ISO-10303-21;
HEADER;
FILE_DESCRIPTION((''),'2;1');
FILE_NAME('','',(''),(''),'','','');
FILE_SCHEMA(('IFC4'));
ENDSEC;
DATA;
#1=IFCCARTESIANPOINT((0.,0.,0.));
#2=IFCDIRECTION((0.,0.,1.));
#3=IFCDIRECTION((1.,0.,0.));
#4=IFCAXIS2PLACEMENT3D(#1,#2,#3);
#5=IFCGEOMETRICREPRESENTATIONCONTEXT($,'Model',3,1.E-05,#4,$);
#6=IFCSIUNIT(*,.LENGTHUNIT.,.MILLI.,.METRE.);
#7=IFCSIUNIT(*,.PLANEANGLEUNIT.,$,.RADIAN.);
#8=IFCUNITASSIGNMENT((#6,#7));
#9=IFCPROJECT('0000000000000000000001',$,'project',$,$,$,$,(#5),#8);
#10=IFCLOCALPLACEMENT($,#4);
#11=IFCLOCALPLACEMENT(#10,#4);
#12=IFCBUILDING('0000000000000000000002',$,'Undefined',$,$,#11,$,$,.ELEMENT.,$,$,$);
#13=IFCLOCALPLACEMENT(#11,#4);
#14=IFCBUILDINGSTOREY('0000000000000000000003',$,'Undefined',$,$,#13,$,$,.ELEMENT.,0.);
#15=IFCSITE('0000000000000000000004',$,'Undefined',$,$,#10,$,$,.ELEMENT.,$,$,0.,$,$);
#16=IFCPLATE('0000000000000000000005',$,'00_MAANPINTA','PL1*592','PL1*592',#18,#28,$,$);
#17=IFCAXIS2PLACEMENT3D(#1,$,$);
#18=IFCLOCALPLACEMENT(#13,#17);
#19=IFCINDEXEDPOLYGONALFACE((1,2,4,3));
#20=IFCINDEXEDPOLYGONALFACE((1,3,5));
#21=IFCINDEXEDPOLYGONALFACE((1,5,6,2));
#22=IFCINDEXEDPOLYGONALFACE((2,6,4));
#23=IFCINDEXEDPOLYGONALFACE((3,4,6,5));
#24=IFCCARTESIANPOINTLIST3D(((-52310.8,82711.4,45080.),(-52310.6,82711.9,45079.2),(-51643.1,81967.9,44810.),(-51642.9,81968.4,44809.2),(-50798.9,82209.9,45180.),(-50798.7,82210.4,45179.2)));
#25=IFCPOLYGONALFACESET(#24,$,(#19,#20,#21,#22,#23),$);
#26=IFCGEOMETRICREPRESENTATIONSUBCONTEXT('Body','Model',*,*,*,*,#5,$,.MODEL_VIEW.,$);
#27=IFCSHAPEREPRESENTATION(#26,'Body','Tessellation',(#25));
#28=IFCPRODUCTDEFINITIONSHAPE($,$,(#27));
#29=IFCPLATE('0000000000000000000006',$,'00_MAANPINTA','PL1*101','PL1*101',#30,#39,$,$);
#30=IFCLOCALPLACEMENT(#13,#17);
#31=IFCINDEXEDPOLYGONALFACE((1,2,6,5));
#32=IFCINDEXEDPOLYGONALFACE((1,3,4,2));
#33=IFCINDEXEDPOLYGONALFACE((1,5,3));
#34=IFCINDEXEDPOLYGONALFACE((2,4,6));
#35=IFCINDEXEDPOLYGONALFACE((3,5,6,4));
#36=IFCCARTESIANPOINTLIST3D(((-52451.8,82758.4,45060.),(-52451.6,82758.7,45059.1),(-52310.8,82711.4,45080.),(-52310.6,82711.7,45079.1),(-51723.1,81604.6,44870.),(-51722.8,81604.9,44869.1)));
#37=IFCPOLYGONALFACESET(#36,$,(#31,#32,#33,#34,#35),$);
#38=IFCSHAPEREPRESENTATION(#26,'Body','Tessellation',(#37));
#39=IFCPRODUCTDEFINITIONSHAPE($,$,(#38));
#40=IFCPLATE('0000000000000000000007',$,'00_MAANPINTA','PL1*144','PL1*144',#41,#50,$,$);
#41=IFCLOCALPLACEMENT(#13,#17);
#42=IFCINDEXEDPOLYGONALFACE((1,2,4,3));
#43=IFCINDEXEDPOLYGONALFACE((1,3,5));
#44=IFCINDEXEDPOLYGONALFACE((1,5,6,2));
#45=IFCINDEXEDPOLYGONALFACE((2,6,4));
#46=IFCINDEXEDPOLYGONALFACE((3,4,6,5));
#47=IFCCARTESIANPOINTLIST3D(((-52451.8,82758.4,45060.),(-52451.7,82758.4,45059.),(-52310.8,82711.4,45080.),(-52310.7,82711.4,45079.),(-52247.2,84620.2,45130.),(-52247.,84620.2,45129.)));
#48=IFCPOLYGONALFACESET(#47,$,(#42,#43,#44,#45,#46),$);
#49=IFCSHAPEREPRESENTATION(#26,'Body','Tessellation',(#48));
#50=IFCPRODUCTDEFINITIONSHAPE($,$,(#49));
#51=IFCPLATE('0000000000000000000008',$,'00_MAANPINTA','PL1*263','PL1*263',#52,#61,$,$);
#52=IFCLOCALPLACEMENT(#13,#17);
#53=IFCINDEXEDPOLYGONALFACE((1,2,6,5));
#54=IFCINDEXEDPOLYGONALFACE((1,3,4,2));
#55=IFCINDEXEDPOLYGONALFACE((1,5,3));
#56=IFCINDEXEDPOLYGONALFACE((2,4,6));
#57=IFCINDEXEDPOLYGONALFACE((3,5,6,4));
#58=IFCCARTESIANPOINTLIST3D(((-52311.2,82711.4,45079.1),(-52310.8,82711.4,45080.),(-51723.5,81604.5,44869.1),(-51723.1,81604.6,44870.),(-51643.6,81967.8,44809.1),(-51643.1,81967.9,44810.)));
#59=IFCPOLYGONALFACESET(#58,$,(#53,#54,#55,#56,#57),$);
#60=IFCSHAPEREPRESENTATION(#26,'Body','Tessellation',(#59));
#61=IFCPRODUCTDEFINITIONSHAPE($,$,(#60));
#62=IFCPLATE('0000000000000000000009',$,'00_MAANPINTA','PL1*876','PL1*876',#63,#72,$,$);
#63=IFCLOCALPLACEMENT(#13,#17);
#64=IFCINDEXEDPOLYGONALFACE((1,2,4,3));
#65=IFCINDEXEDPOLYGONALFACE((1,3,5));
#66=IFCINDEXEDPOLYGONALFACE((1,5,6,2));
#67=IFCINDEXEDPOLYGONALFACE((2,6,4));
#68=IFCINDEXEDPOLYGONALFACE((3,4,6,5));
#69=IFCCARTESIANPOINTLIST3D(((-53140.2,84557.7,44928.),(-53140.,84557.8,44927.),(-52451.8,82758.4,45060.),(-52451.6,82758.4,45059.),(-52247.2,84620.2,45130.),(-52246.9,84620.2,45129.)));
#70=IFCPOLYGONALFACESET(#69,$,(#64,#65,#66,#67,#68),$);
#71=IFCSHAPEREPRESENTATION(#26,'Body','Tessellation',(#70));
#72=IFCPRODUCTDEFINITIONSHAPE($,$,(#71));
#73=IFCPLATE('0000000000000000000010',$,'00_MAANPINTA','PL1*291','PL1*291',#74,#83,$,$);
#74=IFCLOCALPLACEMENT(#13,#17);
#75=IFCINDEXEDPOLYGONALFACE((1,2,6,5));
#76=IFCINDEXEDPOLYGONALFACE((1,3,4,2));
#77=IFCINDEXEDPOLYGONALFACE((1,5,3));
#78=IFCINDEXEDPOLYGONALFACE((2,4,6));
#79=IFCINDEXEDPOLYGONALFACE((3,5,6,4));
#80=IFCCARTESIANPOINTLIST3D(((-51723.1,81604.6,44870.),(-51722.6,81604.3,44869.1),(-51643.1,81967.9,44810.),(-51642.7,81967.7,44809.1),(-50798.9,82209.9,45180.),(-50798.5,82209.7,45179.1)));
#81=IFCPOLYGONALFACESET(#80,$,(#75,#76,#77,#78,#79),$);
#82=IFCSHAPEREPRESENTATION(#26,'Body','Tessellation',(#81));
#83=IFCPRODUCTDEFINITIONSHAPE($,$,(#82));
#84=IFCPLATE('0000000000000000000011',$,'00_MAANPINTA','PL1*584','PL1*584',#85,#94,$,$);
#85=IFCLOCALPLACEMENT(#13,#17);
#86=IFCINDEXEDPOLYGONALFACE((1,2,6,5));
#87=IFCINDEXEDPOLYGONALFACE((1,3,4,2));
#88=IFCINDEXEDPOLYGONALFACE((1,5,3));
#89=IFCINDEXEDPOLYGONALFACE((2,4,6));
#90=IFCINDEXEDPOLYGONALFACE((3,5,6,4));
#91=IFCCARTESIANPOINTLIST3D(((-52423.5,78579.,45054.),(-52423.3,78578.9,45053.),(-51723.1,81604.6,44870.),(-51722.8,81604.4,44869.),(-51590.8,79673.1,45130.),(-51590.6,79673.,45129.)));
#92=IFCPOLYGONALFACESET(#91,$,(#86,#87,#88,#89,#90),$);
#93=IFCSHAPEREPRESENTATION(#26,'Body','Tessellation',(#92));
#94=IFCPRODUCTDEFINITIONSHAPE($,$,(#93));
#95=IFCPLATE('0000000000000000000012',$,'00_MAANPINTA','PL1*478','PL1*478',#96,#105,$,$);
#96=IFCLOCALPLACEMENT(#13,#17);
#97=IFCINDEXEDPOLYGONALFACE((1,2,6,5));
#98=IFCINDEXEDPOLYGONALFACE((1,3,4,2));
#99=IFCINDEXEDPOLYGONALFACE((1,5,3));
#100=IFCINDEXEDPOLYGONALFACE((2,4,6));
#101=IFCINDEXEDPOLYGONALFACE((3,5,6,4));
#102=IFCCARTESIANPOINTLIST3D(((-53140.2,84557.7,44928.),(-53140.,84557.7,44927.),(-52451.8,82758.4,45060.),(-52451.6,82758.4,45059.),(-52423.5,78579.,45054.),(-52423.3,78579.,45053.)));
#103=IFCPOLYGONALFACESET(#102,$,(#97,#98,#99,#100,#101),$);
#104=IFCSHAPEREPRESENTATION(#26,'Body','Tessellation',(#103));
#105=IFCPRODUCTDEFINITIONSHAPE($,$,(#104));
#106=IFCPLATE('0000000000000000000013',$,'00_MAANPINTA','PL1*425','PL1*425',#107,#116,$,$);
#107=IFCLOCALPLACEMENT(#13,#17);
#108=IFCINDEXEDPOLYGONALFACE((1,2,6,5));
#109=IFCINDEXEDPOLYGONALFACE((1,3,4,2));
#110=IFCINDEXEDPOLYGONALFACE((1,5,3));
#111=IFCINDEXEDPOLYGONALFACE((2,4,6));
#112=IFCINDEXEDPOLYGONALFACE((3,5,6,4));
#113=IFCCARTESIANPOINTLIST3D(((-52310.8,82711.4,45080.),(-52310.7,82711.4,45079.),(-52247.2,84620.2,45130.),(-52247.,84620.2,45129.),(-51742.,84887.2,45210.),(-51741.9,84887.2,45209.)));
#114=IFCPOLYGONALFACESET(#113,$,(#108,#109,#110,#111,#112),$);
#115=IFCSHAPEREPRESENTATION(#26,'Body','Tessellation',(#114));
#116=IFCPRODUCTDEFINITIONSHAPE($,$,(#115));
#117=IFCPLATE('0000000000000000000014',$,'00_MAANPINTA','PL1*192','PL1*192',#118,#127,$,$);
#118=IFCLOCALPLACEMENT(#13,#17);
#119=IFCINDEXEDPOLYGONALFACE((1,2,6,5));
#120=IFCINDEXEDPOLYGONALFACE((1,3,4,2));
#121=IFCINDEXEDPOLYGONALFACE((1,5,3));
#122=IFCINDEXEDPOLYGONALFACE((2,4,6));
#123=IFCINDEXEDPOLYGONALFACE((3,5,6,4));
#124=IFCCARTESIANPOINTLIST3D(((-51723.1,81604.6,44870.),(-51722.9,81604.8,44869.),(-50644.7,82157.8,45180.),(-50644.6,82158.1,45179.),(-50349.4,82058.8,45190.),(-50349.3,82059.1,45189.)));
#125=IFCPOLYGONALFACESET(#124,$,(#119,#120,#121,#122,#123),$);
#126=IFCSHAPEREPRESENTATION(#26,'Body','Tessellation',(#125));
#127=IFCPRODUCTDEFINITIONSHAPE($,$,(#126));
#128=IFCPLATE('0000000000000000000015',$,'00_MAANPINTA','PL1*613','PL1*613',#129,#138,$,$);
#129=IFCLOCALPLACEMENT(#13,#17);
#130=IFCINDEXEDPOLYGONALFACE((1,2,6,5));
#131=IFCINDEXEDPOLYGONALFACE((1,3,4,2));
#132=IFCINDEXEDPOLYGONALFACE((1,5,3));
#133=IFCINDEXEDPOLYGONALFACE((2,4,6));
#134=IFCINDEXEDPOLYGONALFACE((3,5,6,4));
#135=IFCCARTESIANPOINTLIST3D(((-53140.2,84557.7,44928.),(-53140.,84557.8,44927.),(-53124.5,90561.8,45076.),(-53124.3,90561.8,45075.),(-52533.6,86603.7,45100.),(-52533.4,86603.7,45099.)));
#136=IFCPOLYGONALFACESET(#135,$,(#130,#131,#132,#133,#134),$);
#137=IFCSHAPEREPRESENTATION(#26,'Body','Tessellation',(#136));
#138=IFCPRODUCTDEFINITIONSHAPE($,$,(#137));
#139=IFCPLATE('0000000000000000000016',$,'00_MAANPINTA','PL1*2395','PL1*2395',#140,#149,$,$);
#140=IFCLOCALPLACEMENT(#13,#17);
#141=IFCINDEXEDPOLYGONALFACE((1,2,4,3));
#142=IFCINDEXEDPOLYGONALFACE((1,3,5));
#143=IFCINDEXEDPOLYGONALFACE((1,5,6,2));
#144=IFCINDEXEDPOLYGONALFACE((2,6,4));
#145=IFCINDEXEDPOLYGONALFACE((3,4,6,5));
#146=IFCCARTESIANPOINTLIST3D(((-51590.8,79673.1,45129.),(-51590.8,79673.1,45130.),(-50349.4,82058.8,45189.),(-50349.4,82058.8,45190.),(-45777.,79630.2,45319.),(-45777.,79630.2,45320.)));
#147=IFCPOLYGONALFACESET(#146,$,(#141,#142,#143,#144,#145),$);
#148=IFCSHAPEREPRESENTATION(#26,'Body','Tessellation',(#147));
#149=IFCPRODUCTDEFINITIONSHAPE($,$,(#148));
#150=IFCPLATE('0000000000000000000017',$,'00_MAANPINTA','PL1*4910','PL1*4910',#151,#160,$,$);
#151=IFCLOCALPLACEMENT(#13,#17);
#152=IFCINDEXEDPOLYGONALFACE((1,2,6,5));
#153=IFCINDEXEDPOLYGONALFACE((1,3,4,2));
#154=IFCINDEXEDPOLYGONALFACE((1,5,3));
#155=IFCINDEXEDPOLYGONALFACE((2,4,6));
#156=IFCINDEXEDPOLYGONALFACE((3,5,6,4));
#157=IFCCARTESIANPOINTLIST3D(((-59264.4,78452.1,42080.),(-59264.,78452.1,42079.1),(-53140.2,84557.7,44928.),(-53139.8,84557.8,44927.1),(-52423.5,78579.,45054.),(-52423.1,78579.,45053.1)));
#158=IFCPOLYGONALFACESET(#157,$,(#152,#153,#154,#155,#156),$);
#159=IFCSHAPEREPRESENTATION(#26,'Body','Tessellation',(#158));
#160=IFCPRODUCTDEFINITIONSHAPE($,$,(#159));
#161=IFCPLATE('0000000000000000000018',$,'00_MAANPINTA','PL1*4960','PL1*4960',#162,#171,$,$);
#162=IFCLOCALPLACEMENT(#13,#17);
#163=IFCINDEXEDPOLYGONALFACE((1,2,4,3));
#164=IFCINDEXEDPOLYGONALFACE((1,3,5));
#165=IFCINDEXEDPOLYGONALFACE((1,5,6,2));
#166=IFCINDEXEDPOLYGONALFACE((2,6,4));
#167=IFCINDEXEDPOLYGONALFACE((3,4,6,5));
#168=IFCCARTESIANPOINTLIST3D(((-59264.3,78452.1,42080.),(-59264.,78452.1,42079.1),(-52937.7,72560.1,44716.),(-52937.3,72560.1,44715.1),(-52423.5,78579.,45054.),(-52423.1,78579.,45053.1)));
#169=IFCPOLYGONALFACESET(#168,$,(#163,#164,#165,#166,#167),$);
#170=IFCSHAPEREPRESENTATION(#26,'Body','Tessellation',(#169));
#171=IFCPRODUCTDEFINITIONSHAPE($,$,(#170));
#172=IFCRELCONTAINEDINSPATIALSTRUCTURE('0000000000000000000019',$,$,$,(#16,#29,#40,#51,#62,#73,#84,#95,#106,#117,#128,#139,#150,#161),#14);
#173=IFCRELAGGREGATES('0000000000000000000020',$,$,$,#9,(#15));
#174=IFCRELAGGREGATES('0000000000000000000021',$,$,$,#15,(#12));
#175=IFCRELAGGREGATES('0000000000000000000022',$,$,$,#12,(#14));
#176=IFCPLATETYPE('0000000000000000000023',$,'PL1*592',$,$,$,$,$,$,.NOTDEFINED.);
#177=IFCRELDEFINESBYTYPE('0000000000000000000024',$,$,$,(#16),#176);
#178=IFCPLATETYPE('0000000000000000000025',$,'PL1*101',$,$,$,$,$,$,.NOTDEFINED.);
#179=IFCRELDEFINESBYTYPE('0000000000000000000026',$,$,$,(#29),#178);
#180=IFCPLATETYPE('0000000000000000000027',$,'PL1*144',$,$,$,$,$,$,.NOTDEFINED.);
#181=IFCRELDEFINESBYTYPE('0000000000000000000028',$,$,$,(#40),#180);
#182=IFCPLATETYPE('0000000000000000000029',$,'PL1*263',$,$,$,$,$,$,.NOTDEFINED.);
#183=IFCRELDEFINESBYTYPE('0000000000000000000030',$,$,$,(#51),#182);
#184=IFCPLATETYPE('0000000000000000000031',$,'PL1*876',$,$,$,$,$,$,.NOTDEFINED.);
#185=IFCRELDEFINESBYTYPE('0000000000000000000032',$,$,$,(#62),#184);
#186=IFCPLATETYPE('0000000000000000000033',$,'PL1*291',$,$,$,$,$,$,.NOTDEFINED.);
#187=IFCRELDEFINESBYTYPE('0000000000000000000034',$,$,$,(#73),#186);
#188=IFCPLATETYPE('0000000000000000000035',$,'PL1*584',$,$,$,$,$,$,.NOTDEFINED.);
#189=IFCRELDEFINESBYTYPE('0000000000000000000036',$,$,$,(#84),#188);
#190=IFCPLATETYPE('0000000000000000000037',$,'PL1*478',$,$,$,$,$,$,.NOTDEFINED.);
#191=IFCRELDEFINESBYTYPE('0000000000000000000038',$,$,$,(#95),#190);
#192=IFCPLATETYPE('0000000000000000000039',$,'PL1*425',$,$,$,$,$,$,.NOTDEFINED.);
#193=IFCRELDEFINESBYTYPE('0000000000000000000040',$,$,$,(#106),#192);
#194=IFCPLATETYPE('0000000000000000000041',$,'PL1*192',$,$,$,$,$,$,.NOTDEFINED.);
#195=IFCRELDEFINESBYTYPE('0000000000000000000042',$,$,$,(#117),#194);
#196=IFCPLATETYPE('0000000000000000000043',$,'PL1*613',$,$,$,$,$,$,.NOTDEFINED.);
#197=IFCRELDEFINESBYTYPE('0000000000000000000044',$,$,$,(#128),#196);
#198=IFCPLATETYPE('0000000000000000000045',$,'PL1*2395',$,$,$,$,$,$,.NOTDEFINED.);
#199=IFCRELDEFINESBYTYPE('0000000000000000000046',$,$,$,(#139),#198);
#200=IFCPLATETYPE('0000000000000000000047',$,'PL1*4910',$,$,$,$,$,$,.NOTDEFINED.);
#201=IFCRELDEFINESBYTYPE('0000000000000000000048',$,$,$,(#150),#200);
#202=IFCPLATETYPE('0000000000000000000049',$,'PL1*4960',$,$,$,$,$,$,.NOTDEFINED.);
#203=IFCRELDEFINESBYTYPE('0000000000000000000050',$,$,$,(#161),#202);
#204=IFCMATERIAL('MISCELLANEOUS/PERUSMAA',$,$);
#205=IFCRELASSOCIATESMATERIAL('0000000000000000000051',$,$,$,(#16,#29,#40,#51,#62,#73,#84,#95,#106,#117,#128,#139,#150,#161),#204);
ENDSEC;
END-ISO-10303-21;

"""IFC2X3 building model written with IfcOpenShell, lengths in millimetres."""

from ifc_helpers import new_model, si_unit, frame, origin_with_axes, place, context, subcontext, project, spatial, polyline, outline, extrude, material, type_object, element, save


model = new_model("IFC2X3")

# Units and contexts
model_context = context("Model", 3, precision=1e-05, world=origin_with_axes())
body_context = subcontext(model_context, "Body", "Model", "MODEL_VIEW")
ifc_project = project(units=[si_unit("LENGTHUNIT", "METRE", prefix="MILLI"), si_unit("PLANEANGLEUNIT", "RADIAN")], contexts=[model_context])

# Site, building, storey
site_placement = place(None, origin_with_axes())
site = spatial("IfcSite", under=ifc_project, at=site_placement, Name="Undefined", CompositionType="ELEMENT", RefElevation=0.0)
building_placement = place(site_placement, origin_with_axes())
building = spatial("IfcBuilding", under=site, at=building_placement, Name="Undefined", CompositionType="ELEMENT")
storey_placement = place(building_placement, origin_with_axes())
storey = spatial("IfcBuildingStorey", under=building, at=storey_placement, Name="Undefined", CompositionType="ELEMENT", Elevation=0.0)

# Plates
ifc_material = material(Name="MISCELLANEOUS/PERUSMAA")
plate_type_1 = type_object("IfcPlateType", Name="PL1*592", PredefinedType="NOTDEFINED")
plate_1_placement = place(storey_placement, frame((-50798.8, 82210.2, 45179.6), z_axis=(0.222021, 0.50274, -0.83544), x_axis=(-0.88587, -0.253964, -0.38825)))
element("IfcPlate", 1, at=plate_1_placement, inside=storey, type_object=plate_type_1, material=ifc_material, Name="00_MAANPINTA", Description="PL1*592", ObjectType="PL1*592", context=body_context, shape_type="SweptSolid", body=[
    extrude(outline(polyline([(0.0, 0.0), (953.0, 0.0), (1250.8, 991.4), (0.0, 0.0)])), frame((0.0, 0.0, -0.5), z_axis=(0.0, 0.0, 1.0), x_axis=(1.0, 0.0, 0.0)), (0.0, 0.0, 1.0), 1.0),
])
plate_type_2 = type_object("IfcPlateType", Name="PL1*101", PredefinedType="NOTDEFINED")
plate_2_placement = place(storey_placement, frame((-51722.9, 81604.7, 44869.5), z_axis=(0.230678, 0.298213, -0.926206), x_axis=(-0.528911, 0.8374, 0.137891)))
element("IfcPlate", 2, at=plate_2_placement, inside=storey, type_object=plate_type_2, material=ifc_material, Name="00_MAANPINTA", Description="PL1*101", ObjectType="PL1*101", context=body_context, shape_type="SweptSolid", body=[
    extrude(outline(polyline([(0.0, 0.0), (1377.9, 0.0), (1266.7, 100.7), (0.0, 0.0)])), frame((0.0, 0.0, -0.5), z_axis=(0.0, 0.0, 1.0), x_axis=(1.0, 0.0, 0.0)), (0.0, 0.0, 1.0), 1.0),
])
plate_type_3 = type_object("IfcPlateType", Name="PL1*144", PredefinedType="NOTDEFINED")
plate_3_placement = place(storey_placement, frame((-52247.1, 84620.2, 45129.5), z_axis=(0.14722, 0.020995, -0.988881), x_axis=(-0.033318, -0.999102, -0.026172)))
element("IfcPlate", 3, at=plate_3_placement, inside=storey, type_object=plate_type_3, material=ifc_material, Name="00_MAANPINTA", Description="PL1*144", ObjectType="PL1*144", context=body_context, shape_type="SweptSolid", body=[
    extrude(outline(polyline([(0.0, 0.0), (1910.4, 0.0), (1868.7, 144.1), (0.0, 0.0)])), frame((0.0, 0.0, -0.5), z_axis=(0.0, 0.0, 1.0), x_axis=(1.0, 0.0, 0.0)), (0.0, 0.0, 1.0), 1.0),
])
plate_type_4 = type_object("IfcPlateType", Name="PL1*263", PredefinedType="NOTDEFINED")
plate_4_placement = place(storey_placement, frame((-52311.0, 82711.4, 45079.5), z_axis=(-0.426603, -0.055251, -0.90275), x_axis=(0.644994, -0.718295, -0.260836)))
element("IfcPlate", 4, at=plate_4_placement, inside=storey, type_object=plate_type_4, material=ifc_material, Name="00_MAANPINTA", Description="PL1*263", ObjectType="PL1*263", context=body_context, shape_type="SweptSolid", body=[
    extrude(outline(polyline([(0.0, 0.0), (1035.1, 0.0), (1228.9, 323.2), (0.0, 0.0)])), frame((0.0, 0.0, -0.5), z_axis=(0.0, 0.0, 1.0), x_axis=(1.0, 0.0, 0.0)), (0.0, 0.0, 1.0), 1.0),
])
plate_type_5 = type_object("IfcPlateType", Name="PL1*876", PredefinedType="NOTDEFINED")
plate_5_placement = place(storey_placement, frame((-52451.7, 82758.4, 45059.5), z_axis=(0.219776, 0.012513, -0.97547), x_axis=(-0.356459, 0.931807, -0.068358)))
element("IfcPlate", 5, at=plate_5_placement, inside=storey, type_object=plate_type_5, material=ifc_material, Name="00_MAANPINTA", Description="PL1*876", ObjectType="PL1*876", context=body_context, shape_type="SweptSolid", body=[
    extrude(outline(polyline([(0.0, 0.0), (1931.0, 0.0), (1657.0, 875.9), (0.0, 0.0)])), frame((0.0, 0.0, -0.5), z_axis=(0.0, 0.0, 1.0), x_axis=(1.0, 0.0, 0.0)), (0.0, 0.0, 1.0), 1.0),
])
plate_type_6 = type_object("IfcPlateType", Name="PL1*291", PredefinedType="NOTDEFINED")
plate_6_placement = place(storey_placement, frame((-51722.8, 81604.4, 44869.6), z_axis=(0.446646, -0.240542, -0.861769), x_axis=(0.21206, 0.964198, -0.159223)))
element("IfcPlate", 6, at=plate_6_placement, inside=storey, type_object=plate_type_6, material=ifc_material, Name="00_MAANPINTA", Description="PL1*291", ObjectType="PL1*291", context=body_context, shape_type="SweptSolid", body=[
    extrude(outline(polyline([(0.0, 0.0), (376.8, 0.0), (730.3, 885.0), (0.0, 0.0)])), frame((0.0, 0.0, -0.5), z_axis=(0.0, 0.0, 1.0), x_axis=(1.0, 0.0, 0.0)), (0.0, 0.0, 1.0), 1.0),
])
plate_type_7 = type_object("IfcPlateType", Name="PL1*584", PredefinedType="NOTDEFINED")
plate_7_placement = place(storey_placement, frame((-51722.9, 81604.5, 44869.5), z_axis=(0.23734, -0.113617, -0.96476), x_axis=(0.067711, -0.988786, 0.133104)))
element("IfcPlate", 7, at=plate_7_placement, inside=storey, type_object=plate_type_7, material=ifc_material, Name="00_MAANPINTA", Description="PL1*584", ObjectType="PL1*584", context=body_context, shape_type="SweptSolid", body=[
    extrude(outline(polyline([(0.0, 0.0), (1953.4, 0.0), (2968.7, 930.2), (0.0, 0.0)])), frame((0.0, 0.0, -0.5), z_axis=(0.0, 0.0, 1.0), x_axis=(1.0, 0.0, 0.0)), (0.0, 0.0, 1.0), 1.0),
])
plate_type_8 = type_object("IfcPlateType", Name="PL1*478", PredefinedType="NOTDEFINED")
plate_8_placement = place(storey_placement, frame((-52423.4, 78579.0, 45053.5), z_axis=(0.195221, 0.002732, -0.980755), x_axis=(-0.118992, 0.992675, -0.02092)))
element("IfcPlate", 8, at=plate_8_placement, inside=storey, type_object=plate_type_8, material=ifc_material, Name="00_MAANPINTA", Description="PL1*478", ObjectType="PL1*478", context=body_context, shape_type="SweptSolid", body=[
    extrude(outline(polyline([(0.0, 0.0), (6022.9, 0.0), (4152.1, 478.4), (0.0, 0.0)])), frame((0.0, 0.0, -0.5), z_axis=(0.0, 0.0, 1.0), x_axis=(1.0, 0.0, 0.0)), (0.0, 0.0, 1.0), 1.0),
])
plate_type_9 = type_object("IfcPlateType", Name="PL1*425", PredefinedType="NOTDEFINED")
plate_9_placement = place(storey_placement, frame((-52310.7, 82711.4, 45079.5), z_axis=(0.145514, 0.021058, -0.989132), x_axis=(0.033318, 0.999102, 0.026172)))
element("IfcPlate", 9, at=plate_9_placement, inside=storey, type_object=plate_type_9, material=ifc_material, Name="00_MAANPINTA", Description="PL1*425", ObjectType="PL1*425", context=body_context, shape_type="SweptSolid", body=[
    extrude(outline(polyline([(0.0, 0.0), (1910.4, 0.0), (2196.2, 501.2), (0.0, 0.0)])), frame((0.0, 0.0, -0.5), z_axis=(0.0, 0.0, 1.0), x_axis=(1.0, 0.0, 0.0)), (0.0, 0.0, 1.0), 1.0),
])
plate_type_10 = type_object("IfcPlateType", Name="PL1*192", PredefinedType="NOTDEFINED")
plate_10_placement = place(storey_placement, frame((-51723.0, 81604.7, 44869.5), z_axis=(0.127473, 0.284005, -0.950311), x_axis=(0.86198, 0.442255, 0.247794)))
element("IfcPlate", 10, at=plate_10_placement, inside=storey, type_object=plate_type_10, material=ifc_material, Name="00_MAANPINTA", Description="PL1*192", ObjectType="PL1*192", context=body_context, shape_type="SweptSolid", body=[
    extrude(outline(polyline([(0.0, 0.0), (1251.0, 0.0), (1464.2, 227.3), (0.0, 0.0)])), frame((0.0, 0.0, -0.5), z_axis=(0.0, 0.0, 1.0), x_axis=(1.0, 0.0, 0.0)), (0.0, 0.0, 1.0), 1.0),
])
plate_type_11 = type_object("IfcPlateType", Name="PL1*613", PredefinedType="NOTDEFINED")
plate_11_placement = place(storey_placement, frame((-53140.1, 84557.7, 44927.5), z_axis=(0.198143, 0.023638, -0.979888), x_axis=(0.002605, 0.999693, 0.024643)))
element("IfcPlate", 11, at=plate_11_placement, inside=storey, type_object=plate_type_11, material=ifc_material, Name="00_MAANPINTA", Description="PL1*613", ObjectType="PL1*613", context=body_context, shape_type="SweptSolid", body=[
    extrude(outline(polyline([(0.0, 0.0), (6005.9, 0.0), (2051.1, 613.3), (0.0, 0.0)])), frame((0.0, 0.0, -0.5), z_axis=(0.0, 0.0, 1.0), x_axis=(1.0, 0.0, 0.0)), (0.0, 0.0, 1.0), 1.0),
])
plate_type_12 = type_object("IfcPlateType", Name="PL1*2395", PredefinedType="NOTDEFINED")
plate_12_placement = place(storey_placement, frame((-50349.4, 82058.8, 45189.5), z_axis=(0.032722, 0.008109, -0.999432), x_axis=(0.882881, -0.468925, 0.025101)))
element("IfcPlate", 12, at=plate_12_placement, inside=storey, type_object=plate_type_12, material=ifc_material, Name="00_MAANPINTA", Description="PL1*2395", ObjectType="PL1*2395", context=body_context, shape_type="SweptSolid", body=[
    extrude(outline(polyline([(0.0, 0.0), (5179.0, 0.0), (21.2, 2689.9), (0.0, 0.0)])), frame((0.0, 0.0, -0.5), z_axis=(0.0, 0.0, 1.0), x_axis=(1.0, 0.0, 0.0)), (0.0, 0.0, 1.0), 1.0),
])
plate_type_13 = type_object("IfcPlateType", Name="PL1*4910", PredefinedType="NOTDEFINED")
plate_13_placement = place(storey_placement, frame((-53140.0, 84557.8, 44927.5), z_axis=(0.39809, 0.028396, -0.916907), x_axis=(0.118992, -0.992675, 0.02092)))
element("IfcPlate", 13, at=plate_13_placement, inside=storey, type_object=plate_type_13, material=ifc_material, Name="00_MAANPINTA", Description="PL1*4910", ObjectType="PL1*4910", context=body_context, shape_type="SweptSolid", body=[
    extrude(outline(polyline([(0.0, 0.0), (6022.9, 0.0), (5272.6, 7422.6), (0.0, 0.0)])), frame((0.0, 0.0, -0.5), z_axis=(0.0, 0.0, 1.0), x_axis=(1.0, 0.0, 0.0)), (0.0, 0.0, 1.0), 1.0),
])
plate_type_14 = type_object("IfcPlateType", Name="PL1*4960", PredefinedType="NOTDEFINED")
plate_14_placement = place(storey_placement, frame((-52423.3, 78579.0, 45053.5), z_axis=(0.398361, 0.017466, -0.917062), x_axis=(-0.08499, -0.994814, -0.055865)))
element("IfcPlate", 14, at=plate_14_placement, inside=storey, type_object=plate_type_14, material=ifc_material, Name="00_MAANPINTA", Description="PL1*4960", ObjectType="PL1*4960", context=body_context, shape_type="SweptSolid", body=[
    extrude(outline(polyline([(0.0, 0.0), (6050.3, 0.0), (873.8, 7409.1), (0.0, 0.0)])), frame((0.0, 0.0, -0.5), z_axis=(0.0, 0.0, 1.0), x_axis=(1.0, 0.0, 0.0)), (0.0, 0.0, 1.0), 1.0),
])

save(model, "model.ifc")
